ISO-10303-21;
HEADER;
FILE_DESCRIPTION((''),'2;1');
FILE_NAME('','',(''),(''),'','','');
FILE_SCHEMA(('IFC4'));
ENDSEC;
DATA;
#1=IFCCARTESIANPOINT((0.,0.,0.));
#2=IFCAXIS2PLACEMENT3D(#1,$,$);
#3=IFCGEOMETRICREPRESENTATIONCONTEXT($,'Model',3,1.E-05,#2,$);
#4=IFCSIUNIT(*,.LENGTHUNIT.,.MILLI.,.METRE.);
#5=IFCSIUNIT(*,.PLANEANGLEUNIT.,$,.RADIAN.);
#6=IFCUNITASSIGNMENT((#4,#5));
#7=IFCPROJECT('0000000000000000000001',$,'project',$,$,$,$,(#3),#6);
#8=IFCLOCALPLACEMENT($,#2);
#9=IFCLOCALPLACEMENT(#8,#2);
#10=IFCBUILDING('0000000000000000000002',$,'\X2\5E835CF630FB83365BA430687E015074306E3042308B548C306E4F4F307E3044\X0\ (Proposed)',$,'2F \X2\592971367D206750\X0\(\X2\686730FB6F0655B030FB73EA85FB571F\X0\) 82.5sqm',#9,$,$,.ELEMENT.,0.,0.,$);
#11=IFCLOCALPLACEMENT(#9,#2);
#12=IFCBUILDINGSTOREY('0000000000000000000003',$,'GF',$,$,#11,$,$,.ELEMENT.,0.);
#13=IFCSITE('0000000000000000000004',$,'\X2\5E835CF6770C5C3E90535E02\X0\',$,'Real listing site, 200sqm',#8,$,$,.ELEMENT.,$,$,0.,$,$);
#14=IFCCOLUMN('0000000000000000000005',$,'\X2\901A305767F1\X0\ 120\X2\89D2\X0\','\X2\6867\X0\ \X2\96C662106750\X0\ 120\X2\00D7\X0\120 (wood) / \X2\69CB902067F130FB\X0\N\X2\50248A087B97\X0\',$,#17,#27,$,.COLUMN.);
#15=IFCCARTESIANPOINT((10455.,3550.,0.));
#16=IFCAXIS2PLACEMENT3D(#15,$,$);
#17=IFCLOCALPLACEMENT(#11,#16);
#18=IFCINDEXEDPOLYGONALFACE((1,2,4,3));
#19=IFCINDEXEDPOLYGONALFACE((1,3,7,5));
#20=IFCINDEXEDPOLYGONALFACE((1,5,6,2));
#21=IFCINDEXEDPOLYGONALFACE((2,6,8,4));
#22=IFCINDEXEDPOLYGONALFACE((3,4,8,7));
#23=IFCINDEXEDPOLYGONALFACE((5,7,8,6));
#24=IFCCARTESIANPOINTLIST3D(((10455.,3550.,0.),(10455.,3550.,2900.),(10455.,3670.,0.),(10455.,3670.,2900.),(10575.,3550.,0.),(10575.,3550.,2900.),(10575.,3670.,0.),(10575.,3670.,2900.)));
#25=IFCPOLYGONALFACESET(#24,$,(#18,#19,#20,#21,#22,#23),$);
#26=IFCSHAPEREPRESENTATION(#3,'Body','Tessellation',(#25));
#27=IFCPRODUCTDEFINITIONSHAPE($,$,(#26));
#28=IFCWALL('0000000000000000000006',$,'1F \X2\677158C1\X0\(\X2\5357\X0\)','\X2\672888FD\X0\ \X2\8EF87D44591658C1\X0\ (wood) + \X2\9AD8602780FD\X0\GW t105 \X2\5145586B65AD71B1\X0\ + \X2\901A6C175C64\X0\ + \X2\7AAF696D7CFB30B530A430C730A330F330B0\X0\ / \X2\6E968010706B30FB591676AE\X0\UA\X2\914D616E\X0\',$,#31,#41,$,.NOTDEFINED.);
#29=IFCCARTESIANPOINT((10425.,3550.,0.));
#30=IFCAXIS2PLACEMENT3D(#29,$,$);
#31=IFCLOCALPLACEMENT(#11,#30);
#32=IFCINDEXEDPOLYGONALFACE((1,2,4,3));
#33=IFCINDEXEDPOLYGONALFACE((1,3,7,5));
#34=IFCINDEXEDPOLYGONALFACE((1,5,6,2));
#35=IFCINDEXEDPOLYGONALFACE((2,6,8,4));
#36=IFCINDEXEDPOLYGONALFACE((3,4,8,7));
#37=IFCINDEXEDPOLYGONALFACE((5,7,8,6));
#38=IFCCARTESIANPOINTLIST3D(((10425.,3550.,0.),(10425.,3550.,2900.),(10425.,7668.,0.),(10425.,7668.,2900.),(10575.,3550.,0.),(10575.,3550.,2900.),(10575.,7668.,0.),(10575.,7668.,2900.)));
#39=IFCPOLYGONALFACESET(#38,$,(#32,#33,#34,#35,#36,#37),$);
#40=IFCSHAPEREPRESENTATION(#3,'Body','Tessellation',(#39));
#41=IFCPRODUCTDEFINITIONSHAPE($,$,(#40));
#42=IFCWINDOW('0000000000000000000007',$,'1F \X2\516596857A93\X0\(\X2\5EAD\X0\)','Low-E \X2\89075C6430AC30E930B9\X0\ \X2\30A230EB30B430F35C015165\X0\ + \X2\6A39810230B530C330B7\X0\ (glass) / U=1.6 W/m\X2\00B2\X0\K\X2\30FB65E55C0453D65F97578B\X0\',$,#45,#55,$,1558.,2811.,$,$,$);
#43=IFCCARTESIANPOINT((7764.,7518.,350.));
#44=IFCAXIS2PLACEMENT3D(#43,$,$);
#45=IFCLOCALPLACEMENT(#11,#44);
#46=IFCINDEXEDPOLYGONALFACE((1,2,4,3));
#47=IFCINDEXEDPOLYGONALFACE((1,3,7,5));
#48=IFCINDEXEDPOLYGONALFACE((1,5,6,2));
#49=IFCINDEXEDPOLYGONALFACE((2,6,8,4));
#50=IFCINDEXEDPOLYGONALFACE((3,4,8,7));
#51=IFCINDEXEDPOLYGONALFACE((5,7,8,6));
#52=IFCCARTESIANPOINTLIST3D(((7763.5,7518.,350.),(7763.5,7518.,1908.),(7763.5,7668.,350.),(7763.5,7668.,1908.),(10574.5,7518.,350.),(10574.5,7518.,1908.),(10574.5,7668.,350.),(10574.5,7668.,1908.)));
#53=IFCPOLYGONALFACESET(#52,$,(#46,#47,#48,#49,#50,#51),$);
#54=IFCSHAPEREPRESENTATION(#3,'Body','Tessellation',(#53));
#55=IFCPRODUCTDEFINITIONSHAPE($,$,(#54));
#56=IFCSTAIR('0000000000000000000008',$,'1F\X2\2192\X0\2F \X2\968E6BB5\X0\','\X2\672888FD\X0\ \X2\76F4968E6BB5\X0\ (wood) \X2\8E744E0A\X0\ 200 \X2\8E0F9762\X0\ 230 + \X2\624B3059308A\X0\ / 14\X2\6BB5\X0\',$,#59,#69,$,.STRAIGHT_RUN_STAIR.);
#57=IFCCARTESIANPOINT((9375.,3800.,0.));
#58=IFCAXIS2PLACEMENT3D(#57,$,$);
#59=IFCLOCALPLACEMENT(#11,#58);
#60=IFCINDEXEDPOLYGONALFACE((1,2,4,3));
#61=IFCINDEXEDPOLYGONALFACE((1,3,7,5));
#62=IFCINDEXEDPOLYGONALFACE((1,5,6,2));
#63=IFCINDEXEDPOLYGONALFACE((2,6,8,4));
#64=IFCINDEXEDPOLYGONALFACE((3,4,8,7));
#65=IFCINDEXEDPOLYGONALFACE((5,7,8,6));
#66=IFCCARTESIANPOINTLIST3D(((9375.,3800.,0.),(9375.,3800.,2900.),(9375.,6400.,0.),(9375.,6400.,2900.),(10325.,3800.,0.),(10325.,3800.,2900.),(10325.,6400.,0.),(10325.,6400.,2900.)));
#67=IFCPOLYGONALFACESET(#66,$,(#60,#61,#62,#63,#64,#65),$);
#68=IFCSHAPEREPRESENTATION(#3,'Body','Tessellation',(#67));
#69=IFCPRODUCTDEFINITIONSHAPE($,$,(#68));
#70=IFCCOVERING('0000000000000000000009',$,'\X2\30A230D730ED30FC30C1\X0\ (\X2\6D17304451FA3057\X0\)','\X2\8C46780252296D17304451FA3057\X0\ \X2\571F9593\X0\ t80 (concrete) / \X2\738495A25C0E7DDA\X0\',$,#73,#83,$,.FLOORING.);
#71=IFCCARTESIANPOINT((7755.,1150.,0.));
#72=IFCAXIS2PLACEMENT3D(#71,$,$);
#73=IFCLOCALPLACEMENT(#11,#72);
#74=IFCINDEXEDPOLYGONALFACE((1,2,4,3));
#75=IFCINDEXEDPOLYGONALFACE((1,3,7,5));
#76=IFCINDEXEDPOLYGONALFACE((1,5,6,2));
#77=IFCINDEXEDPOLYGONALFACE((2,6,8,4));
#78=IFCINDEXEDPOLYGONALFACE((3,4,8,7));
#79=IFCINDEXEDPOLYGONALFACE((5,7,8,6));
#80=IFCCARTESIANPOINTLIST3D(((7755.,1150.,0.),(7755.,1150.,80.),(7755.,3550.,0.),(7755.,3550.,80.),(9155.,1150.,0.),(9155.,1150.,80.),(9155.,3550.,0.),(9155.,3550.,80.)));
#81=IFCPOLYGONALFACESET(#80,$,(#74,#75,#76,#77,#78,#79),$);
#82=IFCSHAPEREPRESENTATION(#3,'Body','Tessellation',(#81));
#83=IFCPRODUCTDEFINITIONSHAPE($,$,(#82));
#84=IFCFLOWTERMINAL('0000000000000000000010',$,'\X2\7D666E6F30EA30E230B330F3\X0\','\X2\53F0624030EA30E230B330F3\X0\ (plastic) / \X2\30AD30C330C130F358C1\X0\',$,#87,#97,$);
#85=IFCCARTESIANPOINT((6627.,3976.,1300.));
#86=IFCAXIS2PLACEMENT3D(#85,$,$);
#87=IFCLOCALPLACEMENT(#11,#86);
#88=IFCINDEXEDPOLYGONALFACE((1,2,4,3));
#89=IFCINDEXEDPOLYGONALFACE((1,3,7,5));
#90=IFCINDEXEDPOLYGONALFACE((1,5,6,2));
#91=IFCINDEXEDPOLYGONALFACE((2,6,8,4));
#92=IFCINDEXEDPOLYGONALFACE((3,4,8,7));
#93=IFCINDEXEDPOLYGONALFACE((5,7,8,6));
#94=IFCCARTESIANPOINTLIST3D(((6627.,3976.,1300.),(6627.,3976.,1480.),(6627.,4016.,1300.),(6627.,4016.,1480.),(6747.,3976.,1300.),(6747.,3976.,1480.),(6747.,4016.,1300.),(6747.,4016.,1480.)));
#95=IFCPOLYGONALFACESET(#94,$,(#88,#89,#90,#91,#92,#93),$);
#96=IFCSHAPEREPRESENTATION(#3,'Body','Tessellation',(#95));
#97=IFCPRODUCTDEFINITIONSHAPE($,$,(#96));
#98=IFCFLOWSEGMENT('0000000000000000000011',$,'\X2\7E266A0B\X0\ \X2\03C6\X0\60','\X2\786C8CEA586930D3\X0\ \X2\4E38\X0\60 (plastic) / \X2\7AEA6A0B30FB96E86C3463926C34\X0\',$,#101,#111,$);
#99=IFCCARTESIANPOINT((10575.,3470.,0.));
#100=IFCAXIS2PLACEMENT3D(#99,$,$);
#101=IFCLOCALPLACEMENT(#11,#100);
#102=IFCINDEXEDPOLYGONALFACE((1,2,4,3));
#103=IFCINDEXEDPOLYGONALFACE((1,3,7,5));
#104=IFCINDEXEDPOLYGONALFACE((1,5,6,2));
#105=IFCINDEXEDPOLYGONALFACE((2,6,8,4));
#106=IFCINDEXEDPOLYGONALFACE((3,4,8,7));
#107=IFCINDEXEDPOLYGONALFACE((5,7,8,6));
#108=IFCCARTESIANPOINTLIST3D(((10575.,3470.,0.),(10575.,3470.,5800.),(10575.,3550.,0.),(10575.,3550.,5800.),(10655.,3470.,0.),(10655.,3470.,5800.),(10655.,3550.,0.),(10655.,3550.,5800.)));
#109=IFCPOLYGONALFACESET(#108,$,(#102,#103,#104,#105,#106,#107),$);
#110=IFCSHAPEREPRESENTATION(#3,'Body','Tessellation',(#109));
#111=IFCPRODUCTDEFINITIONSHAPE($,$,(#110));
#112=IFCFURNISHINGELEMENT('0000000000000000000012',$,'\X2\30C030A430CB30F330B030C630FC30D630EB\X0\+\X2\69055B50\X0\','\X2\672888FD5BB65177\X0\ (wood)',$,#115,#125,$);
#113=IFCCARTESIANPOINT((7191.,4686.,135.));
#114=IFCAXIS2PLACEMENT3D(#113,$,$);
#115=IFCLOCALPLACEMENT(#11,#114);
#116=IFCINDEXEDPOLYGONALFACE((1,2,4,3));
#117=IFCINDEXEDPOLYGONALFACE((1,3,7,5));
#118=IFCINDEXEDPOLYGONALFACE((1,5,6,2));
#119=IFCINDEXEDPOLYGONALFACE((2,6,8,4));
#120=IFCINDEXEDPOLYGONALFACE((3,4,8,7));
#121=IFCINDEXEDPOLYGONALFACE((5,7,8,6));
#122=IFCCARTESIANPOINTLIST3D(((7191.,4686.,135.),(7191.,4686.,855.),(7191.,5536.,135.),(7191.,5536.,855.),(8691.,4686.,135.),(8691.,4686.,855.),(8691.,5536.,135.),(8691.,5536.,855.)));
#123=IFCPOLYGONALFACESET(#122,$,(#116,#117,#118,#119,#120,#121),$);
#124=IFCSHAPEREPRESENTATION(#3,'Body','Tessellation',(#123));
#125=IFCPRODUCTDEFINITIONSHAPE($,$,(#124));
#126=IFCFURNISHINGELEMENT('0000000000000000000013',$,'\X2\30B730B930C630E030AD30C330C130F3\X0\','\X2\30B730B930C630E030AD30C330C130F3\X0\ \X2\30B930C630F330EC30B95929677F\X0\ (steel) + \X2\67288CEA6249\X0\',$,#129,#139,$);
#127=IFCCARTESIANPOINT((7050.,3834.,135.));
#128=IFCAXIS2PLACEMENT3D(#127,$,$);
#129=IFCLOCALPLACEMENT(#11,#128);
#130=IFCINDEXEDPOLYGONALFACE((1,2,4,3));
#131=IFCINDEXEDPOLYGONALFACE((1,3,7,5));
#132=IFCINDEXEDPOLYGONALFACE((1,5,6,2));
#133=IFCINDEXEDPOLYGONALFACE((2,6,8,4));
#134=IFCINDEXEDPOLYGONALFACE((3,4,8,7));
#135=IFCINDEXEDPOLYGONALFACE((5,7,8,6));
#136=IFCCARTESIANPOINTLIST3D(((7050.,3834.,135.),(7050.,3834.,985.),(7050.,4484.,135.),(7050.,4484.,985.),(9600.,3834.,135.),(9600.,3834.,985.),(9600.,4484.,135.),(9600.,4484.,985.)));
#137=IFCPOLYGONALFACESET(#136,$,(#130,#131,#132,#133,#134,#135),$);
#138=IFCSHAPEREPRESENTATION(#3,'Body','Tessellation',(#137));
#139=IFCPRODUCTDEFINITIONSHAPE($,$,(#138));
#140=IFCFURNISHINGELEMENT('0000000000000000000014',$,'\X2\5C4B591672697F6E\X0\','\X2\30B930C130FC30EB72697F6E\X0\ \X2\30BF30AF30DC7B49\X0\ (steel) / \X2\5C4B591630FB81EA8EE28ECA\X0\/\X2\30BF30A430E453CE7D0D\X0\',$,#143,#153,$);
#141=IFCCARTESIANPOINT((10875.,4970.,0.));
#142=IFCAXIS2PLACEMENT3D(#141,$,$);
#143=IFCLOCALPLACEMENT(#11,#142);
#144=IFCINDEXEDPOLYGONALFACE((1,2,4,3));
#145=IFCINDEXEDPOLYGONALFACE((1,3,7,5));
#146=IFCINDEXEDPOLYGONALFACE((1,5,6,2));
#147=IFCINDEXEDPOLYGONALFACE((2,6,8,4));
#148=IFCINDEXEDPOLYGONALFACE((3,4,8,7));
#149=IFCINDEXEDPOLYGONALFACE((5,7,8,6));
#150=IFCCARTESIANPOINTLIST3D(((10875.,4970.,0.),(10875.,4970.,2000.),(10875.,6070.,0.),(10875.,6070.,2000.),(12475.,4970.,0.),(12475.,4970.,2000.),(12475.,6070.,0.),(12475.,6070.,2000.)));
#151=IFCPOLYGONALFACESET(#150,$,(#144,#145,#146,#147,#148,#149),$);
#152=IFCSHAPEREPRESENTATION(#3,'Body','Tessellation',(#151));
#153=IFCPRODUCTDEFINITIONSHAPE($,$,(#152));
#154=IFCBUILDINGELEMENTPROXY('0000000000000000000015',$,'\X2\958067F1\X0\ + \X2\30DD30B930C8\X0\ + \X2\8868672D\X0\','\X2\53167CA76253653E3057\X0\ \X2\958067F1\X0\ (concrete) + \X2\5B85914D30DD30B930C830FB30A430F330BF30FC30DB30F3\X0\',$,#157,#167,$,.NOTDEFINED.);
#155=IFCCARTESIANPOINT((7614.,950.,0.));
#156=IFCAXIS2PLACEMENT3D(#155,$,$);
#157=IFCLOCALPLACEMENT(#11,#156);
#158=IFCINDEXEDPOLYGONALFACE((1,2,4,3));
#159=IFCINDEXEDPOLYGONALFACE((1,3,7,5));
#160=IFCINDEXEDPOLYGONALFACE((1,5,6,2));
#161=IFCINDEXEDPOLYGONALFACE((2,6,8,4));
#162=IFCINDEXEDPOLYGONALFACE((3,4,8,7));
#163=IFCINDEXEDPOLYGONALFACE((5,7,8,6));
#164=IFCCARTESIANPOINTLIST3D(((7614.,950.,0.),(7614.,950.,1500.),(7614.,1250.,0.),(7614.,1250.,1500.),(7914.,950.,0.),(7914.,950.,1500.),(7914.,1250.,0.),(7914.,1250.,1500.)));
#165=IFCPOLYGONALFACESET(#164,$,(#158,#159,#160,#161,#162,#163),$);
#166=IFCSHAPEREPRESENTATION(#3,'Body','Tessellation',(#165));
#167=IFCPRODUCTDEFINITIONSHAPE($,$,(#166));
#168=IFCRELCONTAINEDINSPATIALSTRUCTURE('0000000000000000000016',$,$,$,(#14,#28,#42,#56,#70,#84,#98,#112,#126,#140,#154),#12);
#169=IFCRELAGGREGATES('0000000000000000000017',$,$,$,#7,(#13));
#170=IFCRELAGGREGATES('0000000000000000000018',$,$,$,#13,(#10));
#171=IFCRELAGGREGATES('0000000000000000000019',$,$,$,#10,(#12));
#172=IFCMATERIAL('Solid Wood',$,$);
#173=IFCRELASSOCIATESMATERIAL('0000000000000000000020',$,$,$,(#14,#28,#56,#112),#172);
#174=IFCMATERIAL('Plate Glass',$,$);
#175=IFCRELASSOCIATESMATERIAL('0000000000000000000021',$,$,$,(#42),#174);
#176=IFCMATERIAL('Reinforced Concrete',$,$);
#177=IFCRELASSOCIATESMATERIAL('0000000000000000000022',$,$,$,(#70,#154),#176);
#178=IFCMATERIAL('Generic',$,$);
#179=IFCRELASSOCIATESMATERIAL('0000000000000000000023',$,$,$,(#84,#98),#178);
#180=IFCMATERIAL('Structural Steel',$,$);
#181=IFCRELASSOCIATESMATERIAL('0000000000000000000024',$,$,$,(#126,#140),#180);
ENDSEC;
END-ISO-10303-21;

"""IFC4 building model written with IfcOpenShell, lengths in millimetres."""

from ifc_helpers import new_model, si_unit, frame, frame_2d, origin, place, context, project, spatial, rectangle, extrude, material, element, fill, save


model = new_model("IFC4")

# Units and contexts
model_context = context("Model", 3, precision=1e-05, world=origin())
ifc_project = project(units=[si_unit("LENGTHUNIT", "METRE", prefix="MILLI"), si_unit("PLANEANGLEUNIT", "RADIAN")], contexts=[model_context])

# Site, building, storey
site_placement = place(None, origin())
site = spatial("IfcSite", under=ifc_project, at=site_placement, Name="広島県尾道市", ObjectType="Real listing site, 200sqm", CompositionType="ELEMENT", RefElevation=0.0)
building_placement = place(site_placement, origin())
building = spatial("IfcBuilding", under=site, at=building_placement, Name="広島・茶室と縁側のある和の住まい (Proposed)", ObjectType="2F 天然素材(桧・漆喰・珪藻土) 82.5sqm", CompositionType="ELEMENT", ElevationOfRefHeight=0.0, ElevationOfTerrain=0.0)
storey_placement = place(building_placement, origin())
storey = spatial("IfcBuildingStorey", under=building, at=storey_placement, Name="GF", CompositionType="ELEMENT", Elevation=0.0)

# Column
ifc_material_1 = material(Name="Solid Wood")
column_1_placement = place(storey_placement, frame((10455.0, 3550.0, 0.0)))
element("IfcColumn", 1, at=column_1_placement, inside=storey, material=ifc_material_1, Name="通し柱 120角", Description="桧 集成材 120×120 (wood) / 構造柱・N値計算", PredefinedType="COLUMN", context=model_context, shape_type="SweptSolid", body=[
    extrude(rectangle(XDim=120.0, YDim=120.0, at=frame_2d((60.0, 60.0))), frame((10455.0, 3550.0, 0.0)), (0.0, 0.0, 1.0), 2900.0),
])

# Wall, opening, window
wall_1_placement = place(storey_placement, frame((10425.0, 3550.0, 0.0)))
wall_1 = element("IfcWall", 2, at=wall_1_placement, inside=storey, material=ifc_material_1, Name="1F 東壁(南)", Description="木製 軸組外壁 (wood) + 高性能GW t105 充填断熱 + 通気層 + 窯業系サイディング / 準耐火・外皮UA配慮", PredefinedType="NOTDEFINED", context=model_context, shape_type="SweptSolid", body=[
    extrude(rectangle(XDim=150.0, YDim=4118.0, at=frame_2d((75.0, 2059.0))), frame((10425.0, 3550.0, 0.0)), (0.0, 0.0, 1.0), 2900.0),
])
opening_1_placement = place(storey_placement, frame((7764.0, 7518.0, 350.0)))
opening_1 = element("IfcOpeningElement", 3, at=opening_1_placement, cuts=wall_1, PredefinedType="NOTDEFINED", context=model_context, shape_type="SweptSolid", body=[
    extrude(rectangle(XDim=2811.0, YDim=150.0, at=frame_2d((1405.0, 75.0))), frame((7764.0, 7518.0, 350.0)), (0.0, 0.0, 1.0), 1558.0),
])
ifc_material_2 = material(Name="Plate Glass")
window_placement = place(storey_placement, frame((7764.0, 7518.0, 350.0)))
window = element("IfcWindow", 4, at=window_placement, inside=storey, material=ifc_material_2, Name="1F 入隅窓(庭)", Description="Low-E 複層ガラス アルゴン封入 + 樹脂サッシ (glass) / U=1.6 W/m²K・日射取得型", OverallHeight=1558.0, OverallWidth=2811.0, context=model_context, shape_type="SweptSolid", body=[
    extrude(rectangle(XDim=2811.0, YDim=150.0, at=frame_2d((1405.0, 75.0))), frame((7764.0, 7518.0, 350.0)), (0.0, 0.0, 1.0), 1558.0),
])
fill(opening_1, window)

# Stair
stair_placement = place(storey_placement, frame((9375.0, 3800.0, 0.0)))
element("IfcStair", 5, at=stair_placement, inside=storey, material=ifc_material_1, Name="1F→2F 階段", Description="木製 直階段 (wood) 蹴上 200 踏面 230 + 手すり / 14段", PredefinedType="STRAIGHT_RUN_STAIR", context=model_context, shape_type="SweptSolid", body=[
    extrude(rectangle(XDim=950.0, YDim=2600.0, at=frame_2d((475.0, 1300.0))), frame((9375.0, 3800.0, 0.0)), (0.0, 0.0, 1.0), 2900.0),
])

# Covering
ifc_material_3 = material(Name="Reinforced Concrete")
covering_placement = place(storey_placement, frame((7755.0, 1150.0, 0.0)))
element("IfcCovering", 6, at=covering_placement, inside=storey, material=ifc_material_3, Name="アプローチ (洗い出し)", Description="豆砂利洗い出し 土間 t80 (concrete) / 玄関導線", PredefinedType="FLOORING", context=model_context, shape_type="SweptSolid", body=[
    extrude(rectangle(XDim=1400.0, YDim=2400.0, at=frame_2d((700.0, 1200.0))), frame((7755.0, 1150.0, 0.0)), (0.0, 0.0, 1.0), 80.0),
])

# Flow terminal
ifc_material_4 = material(Name="Generic")
flow_terminal_placement = place(storey_placement, frame((6627.0, 3976.0, 1300.0)))
element("IfcFlowTerminal", 7, at=flow_terminal_placement, inside=storey, material=ifc_material_4, Name="給湯リモコン", Description="台所リモコン (plastic) / キッチン壁", context=model_context, shape_type="SweptSolid", body=[
    extrude(rectangle(XDim=120.0, YDim=40.0, at=frame_2d((60.0, 20.0))), frame((6627.0, 3976.0, 1300.0)), (0.0, 0.0, 1.0), 180.0),
])

# Flow segment
flow_segment_placement = place(storey_placement, frame((10575.0, 3470.0, 0.0)))
element("IfcFlowSegment", 8, at=flow_segment_placement, inside=storey, material=ifc_material_4, Name="縦樋 φ60", Description="硬質塩ビ 丸60 (plastic) / 竪樋・雨水排水", context=model_context, shape_type="SweptSolid", body=[
    extrude(rectangle(XDim=80.0, YDim=80.0, at=frame_2d((40.0, 40.0))), frame((10575.0, 3470.0, 0.0)), (0.0, 0.0, 1.0), 5800.0),
])

# Furnishing elements
furnishing_1_placement = place(storey_placement, frame((7191.0, 4686.0, 135.0)))
element("IfcFurnishingElement", 9, at=furnishing_1_placement, inside=storey, material=ifc_material_1, Name="ダイニングテーブル+椅子", Description="木製家具 (wood)", context=model_context, shape_type="SweptSolid", body=[
    extrude(rectangle(XDim=1500.0, YDim=850.0, at=frame_2d((750.0, 425.0))), frame((7191.0, 4686.0, 135.0)), (0.0, 0.0, 1.0), 720.0),
])
ifc_material_5 = material(Name="Structural Steel")
furnishing_2_placement = place(storey_placement, frame((7050.0, 3834.0, 135.0)))
element("IfcFurnishingElement", 10, at=furnishing_2_placement, inside=storey, material=ifc_material_5, Name="システムキッチン", Description="システムキッチン ステンレス天板 (steel) + 木質扉", context=model_context, shape_type="SweptSolid", body=[
    extrude(rectangle(XDim=2550.0, YDim=650.0, at=frame_2d((1275.0, 325.0))), frame((7050.0, 3834.0, 135.0)), (0.0, 0.0, 1.0), 850.0),
])
furnishing_3_placement = place(storey_placement, frame((10875.0, 4970.0, 0.0)))
element("IfcFurnishingElement", 11, at=furnishing_3_placement, inside=storey, material=ifc_material_5, Name="屋外物置", Description="スチール物置 タクボ等 (steel) / 屋外・自転車/タイヤ収納", context=model_context, shape_type="SweptSolid", body=[
    extrude(rectangle(XDim=1600.0, YDim=1100.0, at=frame_2d((800.0, 550.0))), frame((10875.0, 4970.0, 0.0)), (0.0, 0.0, 1.0), 2000.0),
])

# Building element proxy
proxy_placement = place(storey_placement, frame((7614.0, 950.0, 0.0)))
element("IfcBuildingElementProxy", 12, at=proxy_placement, inside=storey, material=ifc_material_3, Name="門柱 + ポスト + 表札", Description="化粧打放し 門柱 (concrete) + 宅配ポスト・インターホン", PredefinedType="NOTDEFINED", context=model_context, shape_type="SweptSolid", body=[
    extrude(rectangle(XDim=300.0, YDim=300.0, at=frame_2d((150.0, 150.0))), frame((7614.0, 950.0, 0.0)), (0.0, 0.0, 1.0), 1500.0),
])

save(model, "model.ifc")
